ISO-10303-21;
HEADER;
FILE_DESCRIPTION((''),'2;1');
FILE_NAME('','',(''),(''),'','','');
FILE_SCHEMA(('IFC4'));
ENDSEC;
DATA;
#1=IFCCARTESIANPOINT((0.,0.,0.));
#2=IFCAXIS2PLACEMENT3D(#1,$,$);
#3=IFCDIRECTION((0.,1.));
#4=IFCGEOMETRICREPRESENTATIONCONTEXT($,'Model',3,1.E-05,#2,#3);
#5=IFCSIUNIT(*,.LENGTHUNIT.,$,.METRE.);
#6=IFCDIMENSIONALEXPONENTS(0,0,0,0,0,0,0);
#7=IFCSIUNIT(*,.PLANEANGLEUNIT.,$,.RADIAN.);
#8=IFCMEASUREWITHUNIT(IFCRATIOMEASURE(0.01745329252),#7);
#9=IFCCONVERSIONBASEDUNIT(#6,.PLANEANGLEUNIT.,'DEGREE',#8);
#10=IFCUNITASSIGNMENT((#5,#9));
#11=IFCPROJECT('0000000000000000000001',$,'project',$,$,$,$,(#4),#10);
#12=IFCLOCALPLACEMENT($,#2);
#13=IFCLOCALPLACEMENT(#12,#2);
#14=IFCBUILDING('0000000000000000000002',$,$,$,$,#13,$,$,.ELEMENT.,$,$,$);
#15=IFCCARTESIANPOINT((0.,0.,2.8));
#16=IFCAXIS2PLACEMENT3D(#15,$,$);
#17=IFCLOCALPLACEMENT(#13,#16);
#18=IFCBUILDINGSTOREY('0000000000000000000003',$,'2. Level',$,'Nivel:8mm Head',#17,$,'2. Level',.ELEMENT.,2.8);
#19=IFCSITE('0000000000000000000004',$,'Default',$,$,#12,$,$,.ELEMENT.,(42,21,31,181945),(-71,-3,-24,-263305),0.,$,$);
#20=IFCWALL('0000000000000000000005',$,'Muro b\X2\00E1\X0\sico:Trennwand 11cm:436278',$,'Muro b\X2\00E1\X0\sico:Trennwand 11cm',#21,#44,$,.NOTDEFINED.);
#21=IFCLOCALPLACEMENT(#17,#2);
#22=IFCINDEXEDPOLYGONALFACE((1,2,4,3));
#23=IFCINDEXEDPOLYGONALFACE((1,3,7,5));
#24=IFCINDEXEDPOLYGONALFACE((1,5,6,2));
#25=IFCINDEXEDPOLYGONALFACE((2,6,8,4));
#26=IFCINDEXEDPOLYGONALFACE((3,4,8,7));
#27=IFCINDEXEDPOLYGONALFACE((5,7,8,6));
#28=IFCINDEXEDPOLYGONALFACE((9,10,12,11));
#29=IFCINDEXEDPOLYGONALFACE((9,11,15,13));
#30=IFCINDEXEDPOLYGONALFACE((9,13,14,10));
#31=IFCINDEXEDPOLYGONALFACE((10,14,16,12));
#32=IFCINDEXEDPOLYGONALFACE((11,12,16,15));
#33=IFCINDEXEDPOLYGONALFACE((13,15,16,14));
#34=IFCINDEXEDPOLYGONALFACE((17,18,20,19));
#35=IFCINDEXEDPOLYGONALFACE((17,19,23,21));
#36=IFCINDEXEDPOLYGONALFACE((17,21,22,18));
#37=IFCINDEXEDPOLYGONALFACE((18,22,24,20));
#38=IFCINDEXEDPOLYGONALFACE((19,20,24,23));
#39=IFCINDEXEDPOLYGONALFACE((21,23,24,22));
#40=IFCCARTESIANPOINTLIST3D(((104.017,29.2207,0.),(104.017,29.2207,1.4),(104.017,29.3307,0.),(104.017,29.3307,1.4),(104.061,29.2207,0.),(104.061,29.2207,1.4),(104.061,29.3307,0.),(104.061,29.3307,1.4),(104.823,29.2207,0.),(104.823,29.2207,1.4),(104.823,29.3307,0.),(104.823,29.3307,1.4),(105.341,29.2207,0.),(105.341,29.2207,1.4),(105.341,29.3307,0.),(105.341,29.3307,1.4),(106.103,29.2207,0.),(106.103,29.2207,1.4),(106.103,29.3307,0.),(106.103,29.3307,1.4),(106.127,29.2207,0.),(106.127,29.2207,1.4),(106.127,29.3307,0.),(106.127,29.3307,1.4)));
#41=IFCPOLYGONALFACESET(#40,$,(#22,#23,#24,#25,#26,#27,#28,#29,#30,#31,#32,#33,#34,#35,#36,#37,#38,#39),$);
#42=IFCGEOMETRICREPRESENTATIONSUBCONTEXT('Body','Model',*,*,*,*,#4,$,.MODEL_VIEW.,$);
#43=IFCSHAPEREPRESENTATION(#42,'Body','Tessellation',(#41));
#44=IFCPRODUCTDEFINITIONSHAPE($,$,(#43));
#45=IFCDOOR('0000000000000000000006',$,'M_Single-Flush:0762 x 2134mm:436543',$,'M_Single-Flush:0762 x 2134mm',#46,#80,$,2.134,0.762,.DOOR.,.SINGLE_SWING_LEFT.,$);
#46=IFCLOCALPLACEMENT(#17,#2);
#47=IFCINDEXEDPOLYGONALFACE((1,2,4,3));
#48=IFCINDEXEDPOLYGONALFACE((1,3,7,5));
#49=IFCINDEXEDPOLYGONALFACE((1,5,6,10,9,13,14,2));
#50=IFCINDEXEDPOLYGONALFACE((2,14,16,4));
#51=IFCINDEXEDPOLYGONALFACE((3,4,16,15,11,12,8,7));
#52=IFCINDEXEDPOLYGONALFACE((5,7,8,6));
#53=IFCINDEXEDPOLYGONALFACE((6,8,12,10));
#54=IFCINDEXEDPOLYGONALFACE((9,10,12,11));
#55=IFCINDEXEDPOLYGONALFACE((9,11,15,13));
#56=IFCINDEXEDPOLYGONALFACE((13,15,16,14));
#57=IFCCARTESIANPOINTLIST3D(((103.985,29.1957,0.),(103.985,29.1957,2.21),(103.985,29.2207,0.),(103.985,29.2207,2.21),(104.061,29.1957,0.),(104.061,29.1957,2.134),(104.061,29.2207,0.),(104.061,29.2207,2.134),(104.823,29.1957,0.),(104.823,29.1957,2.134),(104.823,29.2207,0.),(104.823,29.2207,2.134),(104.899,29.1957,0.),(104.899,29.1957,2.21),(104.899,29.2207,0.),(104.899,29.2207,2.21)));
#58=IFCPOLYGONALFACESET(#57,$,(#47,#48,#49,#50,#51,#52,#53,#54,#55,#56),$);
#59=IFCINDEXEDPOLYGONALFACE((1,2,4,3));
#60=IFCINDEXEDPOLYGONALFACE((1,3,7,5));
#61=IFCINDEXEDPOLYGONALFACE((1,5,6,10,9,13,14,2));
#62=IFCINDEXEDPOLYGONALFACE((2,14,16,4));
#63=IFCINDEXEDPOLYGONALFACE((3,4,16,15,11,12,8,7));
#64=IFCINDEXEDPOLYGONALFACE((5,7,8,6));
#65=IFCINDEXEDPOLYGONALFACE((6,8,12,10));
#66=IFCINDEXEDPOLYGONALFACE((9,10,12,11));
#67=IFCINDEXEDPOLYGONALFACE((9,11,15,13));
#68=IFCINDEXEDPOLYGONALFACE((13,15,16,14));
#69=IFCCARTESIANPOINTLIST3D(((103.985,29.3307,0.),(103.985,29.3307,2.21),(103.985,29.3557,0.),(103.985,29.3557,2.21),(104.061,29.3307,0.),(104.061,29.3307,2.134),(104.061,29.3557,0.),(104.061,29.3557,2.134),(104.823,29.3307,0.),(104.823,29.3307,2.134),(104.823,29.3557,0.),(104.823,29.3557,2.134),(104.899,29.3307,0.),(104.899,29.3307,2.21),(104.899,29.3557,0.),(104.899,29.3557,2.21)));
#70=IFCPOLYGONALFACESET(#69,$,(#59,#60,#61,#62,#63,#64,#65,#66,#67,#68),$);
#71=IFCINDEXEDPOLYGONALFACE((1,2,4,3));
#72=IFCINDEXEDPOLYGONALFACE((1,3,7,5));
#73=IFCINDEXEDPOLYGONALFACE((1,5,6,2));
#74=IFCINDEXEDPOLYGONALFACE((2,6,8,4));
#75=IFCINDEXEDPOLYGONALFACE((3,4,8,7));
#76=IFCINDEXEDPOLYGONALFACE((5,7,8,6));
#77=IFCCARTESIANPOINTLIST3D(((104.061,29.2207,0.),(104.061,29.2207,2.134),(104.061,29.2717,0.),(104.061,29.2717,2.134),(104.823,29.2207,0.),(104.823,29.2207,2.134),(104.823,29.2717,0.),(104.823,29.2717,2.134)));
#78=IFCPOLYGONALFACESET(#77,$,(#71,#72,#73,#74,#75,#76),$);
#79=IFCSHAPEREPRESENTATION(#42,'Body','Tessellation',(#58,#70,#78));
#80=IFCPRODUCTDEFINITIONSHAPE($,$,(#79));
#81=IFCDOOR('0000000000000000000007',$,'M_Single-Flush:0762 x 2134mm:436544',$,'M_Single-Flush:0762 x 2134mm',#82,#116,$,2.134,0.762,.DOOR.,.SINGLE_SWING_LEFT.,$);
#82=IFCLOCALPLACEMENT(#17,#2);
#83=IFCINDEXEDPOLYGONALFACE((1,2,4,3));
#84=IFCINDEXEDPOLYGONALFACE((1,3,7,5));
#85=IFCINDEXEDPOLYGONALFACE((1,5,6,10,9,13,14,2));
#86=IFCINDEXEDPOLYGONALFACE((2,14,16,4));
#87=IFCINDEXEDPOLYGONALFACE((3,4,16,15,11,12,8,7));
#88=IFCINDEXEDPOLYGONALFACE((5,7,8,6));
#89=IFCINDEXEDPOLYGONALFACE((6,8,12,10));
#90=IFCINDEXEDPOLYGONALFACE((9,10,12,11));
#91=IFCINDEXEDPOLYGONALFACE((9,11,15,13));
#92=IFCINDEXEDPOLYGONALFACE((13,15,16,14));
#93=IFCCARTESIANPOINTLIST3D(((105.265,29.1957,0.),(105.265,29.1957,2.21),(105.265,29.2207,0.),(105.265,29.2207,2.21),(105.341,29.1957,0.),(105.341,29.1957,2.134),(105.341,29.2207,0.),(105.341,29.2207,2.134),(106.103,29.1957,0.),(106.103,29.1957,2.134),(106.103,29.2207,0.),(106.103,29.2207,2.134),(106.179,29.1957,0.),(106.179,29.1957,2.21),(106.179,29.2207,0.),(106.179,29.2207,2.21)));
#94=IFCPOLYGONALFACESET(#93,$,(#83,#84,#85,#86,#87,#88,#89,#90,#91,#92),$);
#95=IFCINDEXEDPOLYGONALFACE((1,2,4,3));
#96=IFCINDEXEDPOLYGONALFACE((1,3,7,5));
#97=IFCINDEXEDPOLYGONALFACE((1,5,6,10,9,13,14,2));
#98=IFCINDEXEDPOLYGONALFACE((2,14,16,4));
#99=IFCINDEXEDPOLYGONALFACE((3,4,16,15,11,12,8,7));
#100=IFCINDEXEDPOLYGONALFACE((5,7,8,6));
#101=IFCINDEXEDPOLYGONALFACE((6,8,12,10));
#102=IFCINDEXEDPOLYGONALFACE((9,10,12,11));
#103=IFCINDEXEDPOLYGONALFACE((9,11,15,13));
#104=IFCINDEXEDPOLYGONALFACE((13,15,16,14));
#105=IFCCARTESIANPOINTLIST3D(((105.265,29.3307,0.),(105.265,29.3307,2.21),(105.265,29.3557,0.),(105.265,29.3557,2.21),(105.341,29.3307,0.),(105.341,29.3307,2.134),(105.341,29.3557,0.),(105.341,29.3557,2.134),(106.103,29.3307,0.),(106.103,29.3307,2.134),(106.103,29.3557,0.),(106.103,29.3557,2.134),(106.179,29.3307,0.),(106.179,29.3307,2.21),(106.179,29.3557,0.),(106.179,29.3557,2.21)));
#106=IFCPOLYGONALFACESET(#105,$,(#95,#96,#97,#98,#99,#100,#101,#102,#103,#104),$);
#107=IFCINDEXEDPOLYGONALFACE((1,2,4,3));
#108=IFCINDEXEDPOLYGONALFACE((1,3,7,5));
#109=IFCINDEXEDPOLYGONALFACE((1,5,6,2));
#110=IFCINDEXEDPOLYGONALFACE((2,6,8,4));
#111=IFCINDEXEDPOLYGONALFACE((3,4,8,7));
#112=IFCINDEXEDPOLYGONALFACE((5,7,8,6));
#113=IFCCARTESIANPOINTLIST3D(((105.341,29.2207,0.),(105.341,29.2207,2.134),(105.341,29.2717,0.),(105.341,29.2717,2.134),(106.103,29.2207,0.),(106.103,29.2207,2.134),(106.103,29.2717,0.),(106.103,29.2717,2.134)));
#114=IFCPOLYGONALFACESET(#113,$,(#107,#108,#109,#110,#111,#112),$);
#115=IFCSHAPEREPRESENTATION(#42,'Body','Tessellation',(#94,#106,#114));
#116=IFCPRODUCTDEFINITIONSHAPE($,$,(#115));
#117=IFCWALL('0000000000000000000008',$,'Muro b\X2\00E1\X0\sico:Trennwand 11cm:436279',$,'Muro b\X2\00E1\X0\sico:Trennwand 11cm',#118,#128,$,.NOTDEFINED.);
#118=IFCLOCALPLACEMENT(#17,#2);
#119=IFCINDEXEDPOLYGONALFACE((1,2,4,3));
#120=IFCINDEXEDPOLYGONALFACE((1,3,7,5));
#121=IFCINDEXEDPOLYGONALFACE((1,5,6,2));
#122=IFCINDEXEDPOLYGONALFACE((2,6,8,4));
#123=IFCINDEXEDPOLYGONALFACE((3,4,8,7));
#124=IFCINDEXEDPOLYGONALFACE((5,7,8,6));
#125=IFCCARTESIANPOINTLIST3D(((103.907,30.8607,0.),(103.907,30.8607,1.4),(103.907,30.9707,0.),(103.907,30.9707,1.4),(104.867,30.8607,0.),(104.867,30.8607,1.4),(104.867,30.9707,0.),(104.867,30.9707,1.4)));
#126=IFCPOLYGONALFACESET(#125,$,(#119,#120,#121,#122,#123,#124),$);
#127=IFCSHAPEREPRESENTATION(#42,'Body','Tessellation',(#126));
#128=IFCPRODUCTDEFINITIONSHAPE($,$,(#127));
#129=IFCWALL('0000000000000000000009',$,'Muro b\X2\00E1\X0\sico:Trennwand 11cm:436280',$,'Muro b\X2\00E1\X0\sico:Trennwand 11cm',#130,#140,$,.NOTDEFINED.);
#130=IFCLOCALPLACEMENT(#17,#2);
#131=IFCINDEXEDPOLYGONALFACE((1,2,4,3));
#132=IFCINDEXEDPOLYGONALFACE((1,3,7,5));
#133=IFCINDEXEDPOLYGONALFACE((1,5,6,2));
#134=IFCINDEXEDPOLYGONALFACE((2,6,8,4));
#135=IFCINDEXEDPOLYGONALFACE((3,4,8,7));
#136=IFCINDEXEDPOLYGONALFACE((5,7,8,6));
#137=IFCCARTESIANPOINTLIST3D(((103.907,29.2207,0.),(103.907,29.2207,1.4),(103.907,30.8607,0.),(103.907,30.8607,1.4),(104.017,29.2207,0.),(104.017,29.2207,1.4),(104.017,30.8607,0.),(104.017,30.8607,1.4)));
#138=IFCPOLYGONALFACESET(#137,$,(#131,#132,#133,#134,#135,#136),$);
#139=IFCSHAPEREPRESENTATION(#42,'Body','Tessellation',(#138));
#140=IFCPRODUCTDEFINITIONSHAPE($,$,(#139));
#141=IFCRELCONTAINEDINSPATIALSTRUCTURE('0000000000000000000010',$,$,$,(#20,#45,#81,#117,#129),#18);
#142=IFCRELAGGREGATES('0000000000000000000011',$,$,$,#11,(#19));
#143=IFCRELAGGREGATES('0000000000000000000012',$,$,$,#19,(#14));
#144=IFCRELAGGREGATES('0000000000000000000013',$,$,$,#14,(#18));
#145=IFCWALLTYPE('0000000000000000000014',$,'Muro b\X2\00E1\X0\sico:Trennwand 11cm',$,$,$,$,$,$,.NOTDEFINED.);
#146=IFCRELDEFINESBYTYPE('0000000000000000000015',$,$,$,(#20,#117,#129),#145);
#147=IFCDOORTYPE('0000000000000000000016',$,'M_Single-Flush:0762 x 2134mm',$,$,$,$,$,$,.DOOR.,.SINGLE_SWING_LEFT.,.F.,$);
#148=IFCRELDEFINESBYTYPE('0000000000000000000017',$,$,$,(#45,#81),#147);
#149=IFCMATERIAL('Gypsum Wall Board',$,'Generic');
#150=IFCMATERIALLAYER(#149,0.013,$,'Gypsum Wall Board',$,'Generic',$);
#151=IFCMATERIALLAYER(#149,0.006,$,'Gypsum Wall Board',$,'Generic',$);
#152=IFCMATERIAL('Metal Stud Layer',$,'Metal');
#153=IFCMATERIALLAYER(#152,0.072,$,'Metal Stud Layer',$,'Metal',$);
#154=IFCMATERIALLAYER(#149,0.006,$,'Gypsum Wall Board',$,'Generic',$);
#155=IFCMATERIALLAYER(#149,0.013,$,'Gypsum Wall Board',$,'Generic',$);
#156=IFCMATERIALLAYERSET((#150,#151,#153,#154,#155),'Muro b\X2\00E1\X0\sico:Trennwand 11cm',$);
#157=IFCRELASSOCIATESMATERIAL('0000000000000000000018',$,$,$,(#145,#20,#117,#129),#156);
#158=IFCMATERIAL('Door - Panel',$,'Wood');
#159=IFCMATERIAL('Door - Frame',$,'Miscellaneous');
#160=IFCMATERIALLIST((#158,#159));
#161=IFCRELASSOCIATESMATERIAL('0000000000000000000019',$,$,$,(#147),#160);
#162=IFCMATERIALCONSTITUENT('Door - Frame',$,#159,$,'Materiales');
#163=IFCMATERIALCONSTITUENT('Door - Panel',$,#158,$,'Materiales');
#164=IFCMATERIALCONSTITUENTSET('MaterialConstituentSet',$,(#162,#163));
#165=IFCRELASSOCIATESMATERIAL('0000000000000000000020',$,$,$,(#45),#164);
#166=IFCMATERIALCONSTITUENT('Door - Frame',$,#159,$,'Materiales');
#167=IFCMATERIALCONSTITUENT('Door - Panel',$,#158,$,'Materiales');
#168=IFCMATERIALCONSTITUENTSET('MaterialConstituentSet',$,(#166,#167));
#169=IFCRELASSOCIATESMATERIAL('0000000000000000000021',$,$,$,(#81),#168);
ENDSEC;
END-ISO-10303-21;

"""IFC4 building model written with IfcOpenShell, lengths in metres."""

from ifc_helpers import new_model, entity, si_unit, converted_unit, direction, frame, frame_2d, origin, origin_2d_with_axis, place, context, subcontext, project, spatial, polyline, rectangle, outline, extrude, clip, halfspace, source, transform, mapped, material, material_list, layer, layer_set, layer_usage, constituent, constituent_set, type_object, type_shapes, element, fill, save


model = new_model("IFC4")

# Units and contexts
model_context = context("Model", 3, precision=1e-05, world=origin(), true_north=direction((0.0, 1.0)))
body_context = subcontext(model_context, "Body", "Model", "MODEL_VIEW")
ifc_project = project(units=[si_unit("LENGTHUNIT", "METRE"), converted_unit("PLANEANGLEUNIT", "DEGREE", entity("IfcRatioMeasure", 0.01745329252), si_unit("PLANEANGLEUNIT", "RADIAN"), dimensions=[0, 0, 0, 0, 0, 0, 0])], contexts=[model_context])

# Site, building, storey
site_placement = place(None, origin())
site = spatial("IfcSite", under=ifc_project, at=site_placement, Name="Default", CompositionType="ELEMENT", RefLatitude=(42, 21, 31, 181945), RefLongitude=(-71, -3, -24, -263305), RefElevation=0.0)
building_placement = place(site_placement, origin())
building = spatial("IfcBuilding", under=site, at=building_placement, CompositionType="ELEMENT")
storey_placement = place(building_placement, frame((0.0, 0.0, 2.8)))
storey = spatial("IfcBuildingStorey", under=building, at=storey_placement, Name="2. Level", ObjectType="Nivel:8mm Head", LongName="2. Level", CompositionType="ELEMENT", Elevation=2.8)

# Shared definitions
ifc_material_1 = material(Name="Gypsum Wall Board", Category="Generic")
ifc_layer_1 = layer(ifc_material_1, 0.013, Name="Gypsum Wall Board", Category="Generic")
ifc_layer_2 = layer(ifc_material_1, 0.006, Name="Gypsum Wall Board", Category="Generic")
ifc_material_2 = material(Name="Metal Stud Layer", Category="Metal")
ifc_layer_3 = layer(ifc_material_2, 0.072, Name="Metal Stud Layer", Category="Metal")
ifc_layer_4 = layer(ifc_material_1, 0.006, Name="Gypsum Wall Board", Category="Generic")
ifc_layer_5 = layer(ifc_material_1, 0.013, Name="Gypsum Wall Board", Category="Generic")
ifc_layer_set_1 = layer_set([ifc_layer_1, ifc_layer_2, ifc_layer_3, ifc_layer_4, ifc_layer_5], Name="Muro básico:Trennwand 11cm")
wall_type_1 = type_object("IfcWallType", Name="Muro básico:Trennwand 11cm", PredefinedType="NOTDEFINED", material=ifc_layer_set_1)

# Shared definitions
ifc_material_3 = material(Name="Door - Frame", Category="Miscellaneous")
ifc_material_4 = material(Name="Door - Panel", Category="Wood")
ifc_material_list_1 = material_list([ifc_material_4, ifc_material_3])
door_type_1 = type_object("IfcDoorType", Name="M_Single-Flush:0762 x 2134mm", OperationType="SINGLE_SWING_LEFT", ParameterTakesPrecedence=False, PredefinedType="DOOR", material=ifc_material_list_1)
shared_shape_1 = source(origin(), body_context, "Body", "SweptSolid", [
    extrude(outline(polyline([(-0.457, -1.124), (0.457, -1.124), (0.457, 1.086), (0.381, 1.086), (0.381, -1.048), (-0.381, -1.048), (-0.381, 1.086), (-0.457, 1.086), (-0.457, -1.124)])), frame((0.381, 0.135, 1.086), z_axis=(0.0, -1.0, 0.0), x_axis=(-1.0, 0.0, 0.0)), (0.0, 0.0, 1.0), 0.025),
    extrude(outline(polyline([(-1.124, -0.457), (1.086, -0.457), (1.086, -0.381), (-1.048, -0.381), (-1.048, 0.381), (1.086, 0.381), (1.086, 0.457), (-1.124, 0.457), (-1.124, -0.457)])), frame((0.381, 0.0, 1.086), z_axis=(0.0, -1.0, 0.0), x_axis=(0.0, 0.0, -1.0)), (0.0, 0.0, 1.0), 0.025),
    extrude(rectangle(XDim=0.762, YDim=0.051, at=origin_2d_with_axis()), frame((0.381, 0.0845, 0.0)), (0.0, 0.0, 1.0), 2.134),
])
type_shapes(door_type_1, [shared_shape_1])

# Wall, openings, doors
ifc_layer_usage_1 = layer_usage(ifc_layer_set_1, "AXIS2", "NEGATIVE", 0.055)
wall_1_placement = place(storey_placement, frame((104.017, 29.2757, 0.0)))
wall_1 = element("IfcWall", 1, at=wall_1_placement, inside=storey, type_object=wall_type_1, material=ifc_layer_usage_1, Name="Muro básico:Trennwand 11cm:436278", ObjectType="Muro básico:Trennwand 11cm", PredefinedType="NOTDEFINED", context=body_context, shape_type="Clipping", body=[
    clip(extrude(rectangle(XDim=2.11, YDim=0.11, at=frame_2d((1.055, 0.0), x_axis=(-1.0, 0.0))), origin(), (0.0, 0.0, 1.0), 1.4), halfspace(origin(), True)),
])
opening_1_placement = place(wall_1_placement, frame((0.806, 0.055, 0.0)))
opening_1 = element("IfcOpeningElement", 2, at=opening_1_placement, cuts=wall_1, ObjectType="Opening", PredefinedType="OPENING", context=body_context, shape_type="SweptSolid", body=[
    extrude(rectangle(XDim=0.762, YDim=2.134, at=frame_2d((1.067, 0.381), x_axis=(0.0, -1.0))), frame((0.0, 0.0, 0.0), z_axis=(0.000001, -1.0, 0.0), x_axis=(0.0, 0.0, 1.0)), (0.0, 0.0, 1.0), 0.11),
])
opening_2_placement = place(wall_1_placement, frame((2.086, 0.055, 0.0)))
opening_2 = element("IfcOpeningElement", 3, at=opening_2_placement, cuts=wall_1, ObjectType="Opening", PredefinedType="OPENING", context=body_context, shape_type="SweptSolid", body=[
    extrude(rectangle(XDim=0.762, YDim=2.134, at=frame_2d((1.067, 0.381), x_axis=(0.0, -1.0))), frame((0.0, 0.0, 0.0), z_axis=(0.000001, -1.0, 0.0), x_axis=(0.0, 0.0, 1.0)), (0.0, 0.0, 1.0), 0.11),
])
ifc_constituent_1 = constituent(ifc_material_3, Name="Door - Frame", Category="Materiales")
ifc_constituent_2 = constituent(ifc_material_4, Name="Door - Panel", Category="Materiales")
ifc_constituent_set_1 = constituent_set(constituents=[ifc_constituent_1, ifc_constituent_2], Name="MaterialConstituentSet")
door_1_placement = place(opening_1_placement, frame((0.0, 0.0, 0.0), z_axis=(0.0, 0.0, 1.0), x_axis=(-1.0, 0.0, 0.0)))
door_1 = element("IfcDoor", 4, at=door_1_placement, inside=storey, type_object=door_type_1, material=ifc_constituent_set_1, Name="M_Single-Flush:0762 x 2134mm:436543", ObjectType="M_Single-Flush:0762 x 2134mm", OperationType="SINGLE_SWING_LEFT", OverallHeight=2.134, OverallWidth=0.762, PredefinedType="DOOR", context=body_context, shape_type="MappedRepresentation", body=[
    mapped(shared_shape_1, transform((0.0, 0.0, 0.0), scale=1.0)),
])
fill(opening_1, door_1)
ifc_constituent_3 = constituent(ifc_material_3, Name="Door - Frame", Category="Materiales")
ifc_constituent_4 = constituent(ifc_material_4, Name="Door - Panel", Category="Materiales")
ifc_constituent_set_2 = constituent_set(constituents=[ifc_constituent_3, ifc_constituent_4], Name="MaterialConstituentSet")
door_2_placement = place(opening_2_placement, frame((0.0, 0.0, 0.0), z_axis=(0.0, 0.0, 1.0), x_axis=(-1.0, 0.0, 0.0)))
door_2 = element("IfcDoor", 5, at=door_2_placement, inside=storey, type_object=door_type_1, material=ifc_constituent_set_2, Name="M_Single-Flush:0762 x 2134mm:436544", ObjectType="M_Single-Flush:0762 x 2134mm", OperationType="SINGLE_SWING_LEFT", OverallHeight=2.134, OverallWidth=0.762, PredefinedType="DOOR", context=body_context, shape_type="MappedRepresentation", body=[
    mapped(shared_shape_1, transform((0.0, 0.0, 0.0), scale=1.0)),
])
fill(opening_2, door_2)

# Walls
ifc_layer_usage_2 = layer_usage(ifc_layer_set_1, "AXIS2", "NEGATIVE", 0.055)
wall_2_placement = place(storey_placement, frame((104.867, 30.9157, 0.0), z_axis=(0.0, 0.0, 1.0), x_axis=(-1.0, 0.0, 0.0)))
element("IfcWall", 6, at=wall_2_placement, inside=storey, type_object=wall_type_1, material=ifc_layer_usage_2, Name="Muro básico:Trennwand 11cm:436279", ObjectType="Muro básico:Trennwand 11cm", PredefinedType="NOTDEFINED", context=body_context, shape_type="Clipping", body=[
    clip(extrude(rectangle(XDim=0.96, YDim=0.11, at=frame_2d((0.48, 0.0), x_axis=(-1.0, 0.0))), origin(), (0.0, 0.0, 1.0), 1.4), halfspace(origin(), True)),
])
ifc_layer_usage_3 = layer_usage(ifc_layer_set_1, "AXIS2", "NEGATIVE", 0.055)
wall_3_placement = place(storey_placement, frame((103.962, 30.8607, 0.0), z_axis=(0.0, 0.0, 1.0), x_axis=(0.0, -1.0, 0.0)))
element("IfcWall", 7, at=wall_3_placement, inside=storey, type_object=wall_type_1, material=ifc_layer_usage_3, Name="Muro básico:Trennwand 11cm:436280", ObjectType="Muro básico:Trennwand 11cm", PredefinedType="NOTDEFINED", context=body_context, shape_type="Clipping", body=[
    clip(extrude(rectangle(XDim=1.64, YDim=0.11, at=frame_2d((0.82, 0.0), x_axis=(-1.0, 0.0))), origin(), (0.0, 0.0, 1.0), 1.4), halfspace(origin(), True)),
])

save(model, "model.ifc")
